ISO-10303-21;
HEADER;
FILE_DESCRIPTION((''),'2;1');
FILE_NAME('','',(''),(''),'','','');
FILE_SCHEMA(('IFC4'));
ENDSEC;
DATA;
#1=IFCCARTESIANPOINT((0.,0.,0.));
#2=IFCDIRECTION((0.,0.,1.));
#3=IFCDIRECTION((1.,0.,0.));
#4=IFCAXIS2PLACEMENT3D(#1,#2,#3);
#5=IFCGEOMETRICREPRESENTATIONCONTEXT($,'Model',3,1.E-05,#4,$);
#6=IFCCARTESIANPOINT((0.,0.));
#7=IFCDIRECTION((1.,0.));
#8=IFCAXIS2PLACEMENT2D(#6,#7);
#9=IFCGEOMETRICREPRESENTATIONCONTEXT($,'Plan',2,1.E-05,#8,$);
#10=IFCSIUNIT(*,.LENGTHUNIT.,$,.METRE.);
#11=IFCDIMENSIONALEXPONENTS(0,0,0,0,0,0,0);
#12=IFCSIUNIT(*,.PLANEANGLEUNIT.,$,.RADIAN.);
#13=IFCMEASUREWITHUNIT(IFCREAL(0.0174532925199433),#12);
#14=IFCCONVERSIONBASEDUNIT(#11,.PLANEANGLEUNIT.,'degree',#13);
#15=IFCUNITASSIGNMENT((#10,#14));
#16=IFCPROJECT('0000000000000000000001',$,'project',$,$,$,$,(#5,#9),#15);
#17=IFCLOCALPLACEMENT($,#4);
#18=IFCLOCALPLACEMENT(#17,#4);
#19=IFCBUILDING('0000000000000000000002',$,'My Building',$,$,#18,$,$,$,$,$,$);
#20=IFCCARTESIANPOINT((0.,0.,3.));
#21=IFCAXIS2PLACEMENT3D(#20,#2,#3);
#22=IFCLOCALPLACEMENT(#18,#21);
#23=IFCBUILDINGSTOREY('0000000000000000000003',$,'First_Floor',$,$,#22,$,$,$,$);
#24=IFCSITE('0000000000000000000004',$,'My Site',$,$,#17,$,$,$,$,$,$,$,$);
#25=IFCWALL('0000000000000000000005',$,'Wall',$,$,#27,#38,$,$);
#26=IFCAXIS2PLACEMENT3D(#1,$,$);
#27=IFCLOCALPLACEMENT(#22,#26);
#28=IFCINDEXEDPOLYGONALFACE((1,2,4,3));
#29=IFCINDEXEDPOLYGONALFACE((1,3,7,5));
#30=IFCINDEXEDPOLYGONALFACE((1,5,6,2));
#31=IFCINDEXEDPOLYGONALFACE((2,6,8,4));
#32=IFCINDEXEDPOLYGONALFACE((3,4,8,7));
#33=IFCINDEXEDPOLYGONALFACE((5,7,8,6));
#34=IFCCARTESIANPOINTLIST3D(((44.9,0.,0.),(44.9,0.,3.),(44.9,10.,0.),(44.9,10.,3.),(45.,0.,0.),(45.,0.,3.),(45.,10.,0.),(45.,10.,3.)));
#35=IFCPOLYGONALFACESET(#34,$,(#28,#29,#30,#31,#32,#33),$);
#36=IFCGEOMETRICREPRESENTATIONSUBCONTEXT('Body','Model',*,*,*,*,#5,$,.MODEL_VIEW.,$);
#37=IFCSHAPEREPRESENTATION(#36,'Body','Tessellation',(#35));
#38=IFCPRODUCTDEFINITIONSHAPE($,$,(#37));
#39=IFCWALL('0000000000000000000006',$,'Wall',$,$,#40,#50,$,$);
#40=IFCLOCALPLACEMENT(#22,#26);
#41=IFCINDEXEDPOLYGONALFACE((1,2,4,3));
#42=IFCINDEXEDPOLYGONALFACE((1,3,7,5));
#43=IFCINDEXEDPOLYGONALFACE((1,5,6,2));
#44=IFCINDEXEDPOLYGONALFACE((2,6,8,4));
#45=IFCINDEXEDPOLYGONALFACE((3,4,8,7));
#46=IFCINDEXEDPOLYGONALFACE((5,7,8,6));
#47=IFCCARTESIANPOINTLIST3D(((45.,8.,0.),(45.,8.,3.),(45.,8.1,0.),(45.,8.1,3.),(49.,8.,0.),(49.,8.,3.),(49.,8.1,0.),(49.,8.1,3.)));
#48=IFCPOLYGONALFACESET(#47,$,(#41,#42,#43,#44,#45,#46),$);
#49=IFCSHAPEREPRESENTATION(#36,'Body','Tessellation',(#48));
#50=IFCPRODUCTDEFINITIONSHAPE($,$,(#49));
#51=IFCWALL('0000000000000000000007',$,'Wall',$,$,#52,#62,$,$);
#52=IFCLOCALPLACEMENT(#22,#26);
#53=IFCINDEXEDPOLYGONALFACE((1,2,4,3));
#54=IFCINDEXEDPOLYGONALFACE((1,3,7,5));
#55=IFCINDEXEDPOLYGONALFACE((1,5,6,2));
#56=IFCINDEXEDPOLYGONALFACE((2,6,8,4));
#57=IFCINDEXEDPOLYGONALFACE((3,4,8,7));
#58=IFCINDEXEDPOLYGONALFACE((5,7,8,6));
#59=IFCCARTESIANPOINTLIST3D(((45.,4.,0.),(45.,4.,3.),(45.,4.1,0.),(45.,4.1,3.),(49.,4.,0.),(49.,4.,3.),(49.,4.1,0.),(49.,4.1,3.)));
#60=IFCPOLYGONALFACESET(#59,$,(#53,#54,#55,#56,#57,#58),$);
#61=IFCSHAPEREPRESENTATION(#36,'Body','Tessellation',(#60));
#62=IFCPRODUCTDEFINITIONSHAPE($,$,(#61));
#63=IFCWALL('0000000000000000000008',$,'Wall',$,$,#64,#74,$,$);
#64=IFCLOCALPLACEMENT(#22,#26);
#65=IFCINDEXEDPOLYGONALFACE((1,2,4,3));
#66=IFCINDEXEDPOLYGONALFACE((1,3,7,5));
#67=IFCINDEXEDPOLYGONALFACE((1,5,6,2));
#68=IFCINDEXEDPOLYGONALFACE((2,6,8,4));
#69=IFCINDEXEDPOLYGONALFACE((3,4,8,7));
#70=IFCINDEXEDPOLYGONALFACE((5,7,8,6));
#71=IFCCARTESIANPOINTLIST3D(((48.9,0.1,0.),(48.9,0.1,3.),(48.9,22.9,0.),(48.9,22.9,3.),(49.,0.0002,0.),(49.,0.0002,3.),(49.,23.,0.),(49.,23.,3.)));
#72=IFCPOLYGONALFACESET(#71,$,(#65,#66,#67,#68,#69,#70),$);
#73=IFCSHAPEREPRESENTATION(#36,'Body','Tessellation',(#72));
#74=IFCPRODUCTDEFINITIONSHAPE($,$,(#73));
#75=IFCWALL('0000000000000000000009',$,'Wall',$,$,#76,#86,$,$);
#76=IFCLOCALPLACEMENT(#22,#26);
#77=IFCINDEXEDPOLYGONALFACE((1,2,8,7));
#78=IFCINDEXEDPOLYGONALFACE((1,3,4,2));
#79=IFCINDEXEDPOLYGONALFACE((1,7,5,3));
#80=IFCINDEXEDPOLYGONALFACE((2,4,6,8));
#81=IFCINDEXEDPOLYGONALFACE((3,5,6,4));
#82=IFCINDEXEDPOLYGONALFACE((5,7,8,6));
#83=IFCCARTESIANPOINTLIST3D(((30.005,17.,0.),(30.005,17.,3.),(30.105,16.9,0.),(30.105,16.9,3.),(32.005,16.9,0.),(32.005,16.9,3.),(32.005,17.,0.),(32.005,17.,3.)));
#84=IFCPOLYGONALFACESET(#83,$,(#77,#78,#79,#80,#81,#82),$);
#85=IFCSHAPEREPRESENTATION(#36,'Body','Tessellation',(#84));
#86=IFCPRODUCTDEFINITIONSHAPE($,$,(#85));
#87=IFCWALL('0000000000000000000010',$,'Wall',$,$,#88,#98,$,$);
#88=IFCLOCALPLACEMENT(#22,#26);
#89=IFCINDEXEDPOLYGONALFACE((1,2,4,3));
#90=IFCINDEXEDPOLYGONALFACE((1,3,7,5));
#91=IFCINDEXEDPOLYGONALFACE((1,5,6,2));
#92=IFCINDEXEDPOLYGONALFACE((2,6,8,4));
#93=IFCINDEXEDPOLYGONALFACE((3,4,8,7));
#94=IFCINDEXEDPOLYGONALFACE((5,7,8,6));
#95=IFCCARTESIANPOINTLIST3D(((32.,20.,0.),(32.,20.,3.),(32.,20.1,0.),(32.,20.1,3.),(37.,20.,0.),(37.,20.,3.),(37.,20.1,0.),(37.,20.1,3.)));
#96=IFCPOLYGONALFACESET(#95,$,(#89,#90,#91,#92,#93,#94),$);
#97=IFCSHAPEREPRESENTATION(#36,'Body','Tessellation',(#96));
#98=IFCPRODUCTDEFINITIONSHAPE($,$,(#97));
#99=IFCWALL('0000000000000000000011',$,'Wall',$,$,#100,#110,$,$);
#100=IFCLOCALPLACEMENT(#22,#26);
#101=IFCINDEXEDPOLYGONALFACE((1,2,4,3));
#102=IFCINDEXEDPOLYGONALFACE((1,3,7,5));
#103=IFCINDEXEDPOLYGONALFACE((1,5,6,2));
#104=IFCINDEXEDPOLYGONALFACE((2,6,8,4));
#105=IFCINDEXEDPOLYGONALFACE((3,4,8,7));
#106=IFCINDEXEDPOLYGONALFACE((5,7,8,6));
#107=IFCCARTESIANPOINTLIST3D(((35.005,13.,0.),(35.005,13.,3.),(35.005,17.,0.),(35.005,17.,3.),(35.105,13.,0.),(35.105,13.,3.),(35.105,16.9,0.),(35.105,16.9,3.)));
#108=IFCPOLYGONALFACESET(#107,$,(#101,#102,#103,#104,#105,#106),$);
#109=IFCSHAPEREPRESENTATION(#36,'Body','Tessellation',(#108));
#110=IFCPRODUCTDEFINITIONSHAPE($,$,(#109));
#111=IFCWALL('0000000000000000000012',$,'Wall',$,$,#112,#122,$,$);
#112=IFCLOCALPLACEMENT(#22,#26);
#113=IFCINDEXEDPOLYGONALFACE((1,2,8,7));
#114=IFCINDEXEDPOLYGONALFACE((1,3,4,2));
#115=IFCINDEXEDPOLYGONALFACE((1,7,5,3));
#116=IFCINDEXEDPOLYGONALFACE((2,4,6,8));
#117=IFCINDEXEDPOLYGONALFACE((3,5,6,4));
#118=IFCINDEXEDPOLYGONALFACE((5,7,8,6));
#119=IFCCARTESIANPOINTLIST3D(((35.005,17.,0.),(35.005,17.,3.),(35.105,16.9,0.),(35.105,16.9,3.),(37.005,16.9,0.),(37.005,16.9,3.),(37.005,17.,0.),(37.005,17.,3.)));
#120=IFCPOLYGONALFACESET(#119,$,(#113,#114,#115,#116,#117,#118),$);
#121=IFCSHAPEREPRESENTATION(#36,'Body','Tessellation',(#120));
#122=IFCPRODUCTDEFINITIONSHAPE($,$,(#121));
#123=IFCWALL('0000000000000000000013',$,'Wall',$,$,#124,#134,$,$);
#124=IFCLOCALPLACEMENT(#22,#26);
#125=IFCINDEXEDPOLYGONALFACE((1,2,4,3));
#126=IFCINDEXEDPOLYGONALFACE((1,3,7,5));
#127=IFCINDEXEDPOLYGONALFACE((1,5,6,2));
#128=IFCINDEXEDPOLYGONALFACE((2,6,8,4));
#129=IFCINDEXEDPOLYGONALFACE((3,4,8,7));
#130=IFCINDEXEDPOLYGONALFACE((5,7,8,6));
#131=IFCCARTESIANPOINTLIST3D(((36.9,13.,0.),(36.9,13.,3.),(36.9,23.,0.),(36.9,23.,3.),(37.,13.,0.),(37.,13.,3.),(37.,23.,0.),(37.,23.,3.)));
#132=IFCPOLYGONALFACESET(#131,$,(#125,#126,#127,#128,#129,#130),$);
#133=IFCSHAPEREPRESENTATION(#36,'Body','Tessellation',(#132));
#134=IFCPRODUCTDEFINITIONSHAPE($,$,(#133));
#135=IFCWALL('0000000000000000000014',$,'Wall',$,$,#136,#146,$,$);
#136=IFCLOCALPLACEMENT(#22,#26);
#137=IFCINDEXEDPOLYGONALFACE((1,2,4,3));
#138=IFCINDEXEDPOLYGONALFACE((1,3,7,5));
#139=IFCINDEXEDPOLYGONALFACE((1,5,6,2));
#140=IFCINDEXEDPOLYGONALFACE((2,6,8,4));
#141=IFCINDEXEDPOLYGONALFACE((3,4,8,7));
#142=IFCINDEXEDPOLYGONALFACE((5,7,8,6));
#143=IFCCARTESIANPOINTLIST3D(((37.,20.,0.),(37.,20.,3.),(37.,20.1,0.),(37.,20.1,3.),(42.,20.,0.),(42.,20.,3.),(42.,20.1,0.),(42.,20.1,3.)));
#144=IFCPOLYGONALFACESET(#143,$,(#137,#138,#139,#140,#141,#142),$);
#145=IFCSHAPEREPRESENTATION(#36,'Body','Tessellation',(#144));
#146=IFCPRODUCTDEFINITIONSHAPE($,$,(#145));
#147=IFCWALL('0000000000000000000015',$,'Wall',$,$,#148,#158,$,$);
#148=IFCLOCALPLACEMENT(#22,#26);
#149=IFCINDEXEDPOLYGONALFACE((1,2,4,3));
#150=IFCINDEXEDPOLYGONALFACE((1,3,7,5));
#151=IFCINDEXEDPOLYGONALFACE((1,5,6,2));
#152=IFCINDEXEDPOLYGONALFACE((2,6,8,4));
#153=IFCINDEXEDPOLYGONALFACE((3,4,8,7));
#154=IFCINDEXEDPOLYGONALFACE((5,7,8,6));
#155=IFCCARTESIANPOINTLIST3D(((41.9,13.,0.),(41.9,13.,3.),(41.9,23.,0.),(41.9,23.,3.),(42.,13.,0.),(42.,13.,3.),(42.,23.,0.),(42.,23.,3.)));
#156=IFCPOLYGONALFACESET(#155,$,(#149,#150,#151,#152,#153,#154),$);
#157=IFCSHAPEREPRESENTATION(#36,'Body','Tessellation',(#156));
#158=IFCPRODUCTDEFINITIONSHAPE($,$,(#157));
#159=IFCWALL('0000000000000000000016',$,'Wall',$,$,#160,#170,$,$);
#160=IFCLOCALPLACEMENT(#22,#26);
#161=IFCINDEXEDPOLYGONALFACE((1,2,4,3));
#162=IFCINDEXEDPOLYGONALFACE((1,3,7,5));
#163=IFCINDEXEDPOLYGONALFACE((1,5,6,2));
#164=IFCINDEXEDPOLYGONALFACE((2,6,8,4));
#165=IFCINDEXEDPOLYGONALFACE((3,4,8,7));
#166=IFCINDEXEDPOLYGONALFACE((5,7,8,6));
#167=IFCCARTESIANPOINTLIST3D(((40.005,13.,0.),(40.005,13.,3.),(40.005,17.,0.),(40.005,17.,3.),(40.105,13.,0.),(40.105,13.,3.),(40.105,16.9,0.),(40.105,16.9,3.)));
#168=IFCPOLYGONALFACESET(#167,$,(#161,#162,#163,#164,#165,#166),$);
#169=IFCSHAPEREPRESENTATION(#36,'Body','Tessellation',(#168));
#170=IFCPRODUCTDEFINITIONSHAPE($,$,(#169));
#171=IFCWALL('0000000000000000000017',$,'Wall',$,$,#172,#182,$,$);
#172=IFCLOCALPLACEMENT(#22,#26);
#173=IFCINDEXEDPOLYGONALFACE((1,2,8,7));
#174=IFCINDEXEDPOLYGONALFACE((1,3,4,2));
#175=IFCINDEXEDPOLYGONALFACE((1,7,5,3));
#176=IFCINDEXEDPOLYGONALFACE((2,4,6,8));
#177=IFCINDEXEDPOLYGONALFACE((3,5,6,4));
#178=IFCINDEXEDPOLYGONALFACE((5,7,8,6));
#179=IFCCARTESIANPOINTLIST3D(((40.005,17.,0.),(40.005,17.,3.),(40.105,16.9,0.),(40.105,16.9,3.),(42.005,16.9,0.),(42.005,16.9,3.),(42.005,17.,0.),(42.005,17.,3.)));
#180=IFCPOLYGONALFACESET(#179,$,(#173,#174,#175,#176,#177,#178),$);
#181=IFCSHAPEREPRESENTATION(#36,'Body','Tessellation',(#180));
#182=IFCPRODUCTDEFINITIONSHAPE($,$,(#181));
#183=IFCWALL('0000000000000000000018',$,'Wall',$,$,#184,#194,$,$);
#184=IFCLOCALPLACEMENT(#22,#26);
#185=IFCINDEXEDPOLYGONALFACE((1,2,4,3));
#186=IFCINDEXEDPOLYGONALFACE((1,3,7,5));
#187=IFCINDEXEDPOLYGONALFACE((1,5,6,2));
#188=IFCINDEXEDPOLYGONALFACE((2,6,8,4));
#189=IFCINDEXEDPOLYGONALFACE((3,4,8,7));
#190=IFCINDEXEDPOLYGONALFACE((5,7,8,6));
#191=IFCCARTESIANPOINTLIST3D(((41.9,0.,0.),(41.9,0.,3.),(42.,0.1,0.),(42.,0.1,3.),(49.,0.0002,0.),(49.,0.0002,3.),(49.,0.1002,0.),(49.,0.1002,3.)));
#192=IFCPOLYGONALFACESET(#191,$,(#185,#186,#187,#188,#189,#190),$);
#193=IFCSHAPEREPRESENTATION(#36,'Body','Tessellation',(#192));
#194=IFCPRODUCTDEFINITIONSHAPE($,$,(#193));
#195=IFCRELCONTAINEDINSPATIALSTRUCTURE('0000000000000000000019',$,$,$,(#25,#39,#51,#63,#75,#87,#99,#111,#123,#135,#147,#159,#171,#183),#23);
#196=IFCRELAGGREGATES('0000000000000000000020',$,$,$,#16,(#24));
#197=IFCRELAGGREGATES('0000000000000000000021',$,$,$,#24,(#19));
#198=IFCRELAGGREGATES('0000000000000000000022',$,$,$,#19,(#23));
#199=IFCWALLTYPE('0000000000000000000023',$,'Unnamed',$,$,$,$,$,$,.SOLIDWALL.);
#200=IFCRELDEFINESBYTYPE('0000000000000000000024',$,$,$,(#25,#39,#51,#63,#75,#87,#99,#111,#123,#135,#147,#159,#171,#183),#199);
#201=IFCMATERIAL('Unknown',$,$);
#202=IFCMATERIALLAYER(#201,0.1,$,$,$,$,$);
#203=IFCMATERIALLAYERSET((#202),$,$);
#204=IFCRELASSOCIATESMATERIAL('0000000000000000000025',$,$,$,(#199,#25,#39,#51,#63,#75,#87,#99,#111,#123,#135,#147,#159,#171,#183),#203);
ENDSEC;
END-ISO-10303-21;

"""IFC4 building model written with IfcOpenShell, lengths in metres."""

from ifc_helpers import new_model, entity, si_unit, converted_unit, frame, origin_with_axes, origin_2d_with_axis, place, context, subcontext, project, spatial, line, indexed_curve, outline, extrude, material, layer, layer_set, layer_usage, type_object, element, save


model = new_model("IFC4")

# Units and contexts
model_context = context("Model", 3, precision=1e-05, world=origin_with_axes())
plan_context = context("Plan", 2, precision=1e-05, world=origin_2d_with_axis())
body_context_1 = subcontext(model_context, "Body", "Model", "MODEL_VIEW")
ifc_project = project(units=[si_unit("LENGTHUNIT", "METRE"), converted_unit("PLANEANGLEUNIT", "degree", entity("IfcReal", 0.0174532925199433), si_unit("PLANEANGLEUNIT", "RADIAN"), dimensions=[0, 0, 0, 0, 0, 0, 0])], contexts=[model_context, plan_context])

# Site, building, storey
site_placement = place(None, origin_with_axes())
site = spatial("IfcSite", under=ifc_project, at=site_placement, Name="My Site")
building_placement = place(site_placement, origin_with_axes())
building = spatial("IfcBuilding", under=site, at=building_placement, Name="My Building")
storey_placement = place(building_placement, frame((0.0, 0.0, 3.0), z_axis=(0.0, 0.0, 1.0), x_axis=(1.0, 0.0, 0.0)))
storey = spatial("IfcBuildingStorey", under=building, at=storey_placement, Name="First_Floor")

# Shared definitions
ifc_material = material(Name="Unknown")
ifc_layer = layer(ifc_material, 0.1)
ifc_layer_set = layer_set([ifc_layer])
wall_type = type_object("IfcWallType", Name="Unnamed", PredefinedType="SOLIDWALL", material=ifc_layer_set)

# Walls
ifc_layer_usage_1 = layer_usage(ifc_layer_set, "AXIS2", "POSITIVE", 0.0)
wall_1_placement = place(storey_placement, frame((44.9, 10.0, 0.0), z_axis=(0.0, 0.0, 1.0), x_axis=(0.0, -1.0, 0.0)))
element("IfcWall", 1, at=wall_1_placement, inside=storey, type_object=wall_type, material=ifc_layer_usage_1, Name="Wall", context=body_context_1, shape_type="SweptSolid", body=[
    extrude(outline(indexed_curve([(0.0, 0.0), (0.0, 0.1), (10.0, 0.1), (10.0, 0.0)], segments=[line(1, 2, 3, 4, 1)])), origin_with_axes(), (0.0, 0.0, 1.0), 3.0),
])
ifc_layer_usage_2 = layer_usage(ifc_layer_set, "AXIS2", "POSITIVE", 0.0)
wall_2_placement = place(storey_placement, frame((45.0, 8.0, 0.0), z_axis=(0.0, 0.0, 1.0), x_axis=(1.0, 0.0, 0.0)))
element("IfcWall", 2, at=wall_2_placement, inside=storey, type_object=wall_type, material=ifc_layer_usage_2, Name="Wall", context=body_context_1, shape_type="SweptSolid", body=[
    extrude(outline(indexed_curve([(0.0, 0.0), (0.0, 0.1), (4.0, 0.1), (4.0, 0.0)], segments=[line(1, 2, 3, 4, 1)])), origin_with_axes(), (0.0, 0.0, 1.0), 3.0),
])
ifc_layer_usage_3 = layer_usage(ifc_layer_set, "AXIS2", "POSITIVE", 0.0)
wall_3_placement = place(storey_placement, frame((45.0, 4.0, 0.0), z_axis=(0.0, 0.0, 1.0), x_axis=(1.0, 0.0, 0.0)))
element("IfcWall", 3, at=wall_3_placement, inside=storey, type_object=wall_type, material=ifc_layer_usage_3, Name="Wall", context=body_context_1, shape_type="SweptSolid", body=[
    extrude(outline(indexed_curve([(0.0, 0.0), (0.0, 0.1), (4.0, 0.1), (4.0, 0.0)], segments=[line(1, 2, 3, 4, 1)])), origin_with_axes(), (0.0, 0.0, 1.0), 3.0),
])
ifc_layer_usage_4 = layer_usage(ifc_layer_set, "AXIS2", "POSITIVE", 0.0)
wall_4_placement = place(storey_placement, frame((48.9, 22.9, 0.0), z_axis=(0.0, 0.0, 1.0), x_axis=(0.0, -1.0, 0.0)))
element("IfcWall", 4, at=wall_4_placement, inside=storey, type_object=wall_type, material=ifc_layer_usage_4, Name="Wall", context=body_context_1, shape_type="SweptSolid", body=[
    extrude(outline(indexed_curve([(0.0, 0.0), (-0.1, 0.1), (22.8998, 0.1), (22.8, 0.0)], segments=[line(1, 2, 3, 4, 1)])), origin_with_axes(), (0.0, 0.0, 1.0), 3.0),
])
ifc_layer_usage_5 = layer_usage(ifc_layer_set, "AXIS2", "POSITIVE", 0.0)
wall_5_placement = place(storey_placement, frame((32.005, 17.0, 0.0), z_axis=(0.0, 0.0, 1.0), x_axis=(-1.0, 0.0, 0.0)))
element("IfcWall", 5, at=wall_5_placement, inside=storey, type_object=wall_type, material=ifc_layer_usage_5, Name="Wall", context=body_context_1, shape_type="SweptSolid", body=[
    extrude(outline(indexed_curve([(0.0, 0.0), (0.0, 0.1), (1.9, 0.1), (2.0, 0.0)], segments=[line(1, 2, 3, 4, 1)])), origin_with_axes(), (0.0, 0.0, 1.0), 3.0),
])
ifc_layer_usage_6 = layer_usage(ifc_layer_set, "AXIS2", "POSITIVE", 0.0)
wall_6_placement = place(storey_placement, frame((32.0, 20.0, 0.0), z_axis=(0.0, 0.0, 1.0), x_axis=(1.0, 0.0, 0.0)))
element("IfcWall", 6, at=wall_6_placement, inside=storey, type_object=wall_type, material=ifc_layer_usage_6, Name="Wall", context=body_context_1, shape_type="SweptSolid", body=[
    extrude(outline(indexed_curve([(0.0, 0.0), (0.0, 0.1), (5.0, 0.1), (5.0, 0.0)], segments=[line(1, 2, 3, 4, 1)])), origin_with_axes(), (0.0, 0.0, 1.0), 3.0),
])
ifc_layer_usage_7 = layer_usage(ifc_layer_set, "AXIS2", "POSITIVE", 0.0)
wall_7_placement = place(storey_placement, frame((35.005, 17.0, 0.0), z_axis=(0.0, 0.0, 1.0), x_axis=(0.0, -1.0, 0.0)))
element("IfcWall", 7, at=wall_7_placement, inside=storey, type_object=wall_type, material=ifc_layer_usage_7, Name="Wall", context=body_context_1, shape_type="SweptSolid", body=[
    extrude(outline(indexed_curve([(0.0, 0.0), (0.1, 0.1), (4.0, 0.1), (4.0, 0.0)], segments=[line(1, 2, 3, 4, 1)])), origin_with_axes(), (0.0, 0.0, 1.0), 3.0),
])
ifc_layer_usage_8 = layer_usage(ifc_layer_set, "AXIS2", "POSITIVE", 0.0)
wall_8_placement = place(storey_placement, frame((37.005, 17.0, 0.0), z_axis=(0.0, 0.0, 1.0), x_axis=(-1.0, 0.0, 0.0)))
element("IfcWall", 8, at=wall_8_placement, inside=storey, type_object=wall_type, material=ifc_layer_usage_8, Name="Wall", context=body_context_1, shape_type="SweptSolid", body=[
    extrude(outline(indexed_curve([(0.0, 0.0), (0.0, 0.1), (1.9, 0.1), (2.0, 0.0)], segments=[line(1, 2, 3, 4, 1)])), origin_with_axes(), (0.0, 0.0, 1.0), 3.0),
])
ifc_layer_usage_9 = layer_usage(ifc_layer_set, "AXIS2", "POSITIVE", 0.0)
wall_9_placement = place(storey_placement, frame((36.9, 23.0, 0.0), z_axis=(0.0, 0.0, 1.0), x_axis=(0.0, -1.0, 0.0)))
element("IfcWall", 9, at=wall_9_placement, inside=storey, type_object=wall_type, material=ifc_layer_usage_9, Name="Wall", context=body_context_1, shape_type="SweptSolid", body=[
    extrude(outline(indexed_curve([(0.0, 0.0), (0.0, 0.1), (10.0, 0.1), (10.0, 0.0)], segments=[line(1, 2, 3, 4, 1)])), origin_with_axes(), (0.0, 0.0, 1.0), 3.0),
])
ifc_layer_usage_10 = layer_usage(ifc_layer_set, "AXIS2", "POSITIVE", 0.0)
wall_10_placement = place(storey_placement, frame((37.0, 20.0, 0.0), z_axis=(0.0, 0.0, 1.0), x_axis=(1.0, 0.0, 0.0)))
element("IfcWall", 10, at=wall_10_placement, inside=storey, type_object=wall_type, material=ifc_layer_usage_10, Name="Wall", context=body_context_1, shape_type="SweptSolid", body=[
    extrude(outline(indexed_curve([(0.0, 0.0), (0.0, 0.1), (5.0, 0.1), (5.0, 0.0)], segments=[line(1, 2, 3, 4, 1)])), origin_with_axes(), (0.0, 0.0, 1.0), 3.0),
])
ifc_layer_usage_11 = layer_usage(ifc_layer_set, "AXIS2", "POSITIVE", 0.0)
wall_11_placement = place(storey_placement, frame((41.9, 23.0, 0.0), z_axis=(0.0, 0.0, 1.0), x_axis=(0.0, -1.0, 0.0)))
element("IfcWall", 11, at=wall_11_placement, inside=storey, type_object=wall_type, material=ifc_layer_usage_11, Name="Wall", context=body_context_1, shape_type="SweptSolid", body=[
    extrude(outline(indexed_curve([(0.0, 0.0), (0.0, 0.1), (10.0, 0.1), (10.0, 0.0)], segments=[line(1, 2, 3, 4, 1)])), origin_with_axes(), (0.0, 0.0, 1.0), 3.0),
])
ifc_layer_usage_12 = layer_usage(ifc_layer_set, "AXIS2", "POSITIVE", 0.0)
wall_12_placement = place(storey_placement, frame((40.005, 17.0, 0.0), z_axis=(0.0, 0.0, 1.0), x_axis=(0.0, -1.0, 0.0)))
element("IfcWall", 12, at=wall_12_placement, inside=storey, type_object=wall_type, material=ifc_layer_usage_12, Name="Wall", context=body_context_1, shape_type="SweptSolid", body=[
    extrude(outline(indexed_curve([(0.0, 0.0), (0.1, 0.1), (4.0, 0.1), (4.0, 0.0)], segments=[line(1, 2, 3, 4, 1)])), origin_with_axes(), (0.0, 0.0, 1.0), 3.0),
])
ifc_layer_usage_13 = layer_usage(ifc_layer_set, "AXIS2", "POSITIVE", 0.0)
wall_13_placement = place(storey_placement, frame((42.005, 17.0, 0.0), z_axis=(0.0, 0.0, 1.0), x_axis=(-1.0, 0.0, 0.0)))
element("IfcWall", 13, at=wall_13_placement, inside=storey, type_object=wall_type, material=ifc_layer_usage_13, Name="Wall", context=body_context_1, shape_type="SweptSolid", body=[
    extrude(outline(indexed_curve([(0.0, 0.0), (0.0, 0.1), (1.9, 0.1), (2.0, 0.0)], segments=[line(1, 2, 3, 4, 1)])), origin_with_axes(), (0.0, 0.0, 1.0), 3.0),
])
ifc_layer_usage_14 = layer_usage(ifc_layer_set, "AXIS2", "POSITIVE", 0.0)
wall_14_placement = place(storey_placement, frame((41.9, 0.0, 0.0), z_axis=(0.0, 0.0, 1.0), x_axis=(1.0, 0.000029, 0.0)))
element("IfcWall", 14, at=wall_14_placement, inside=storey, type_object=wall_type, material=ifc_layer_usage_14, Name="Wall", context=body_context_1, shape_type="SweptSolid", body=[
    extrude(outline(indexed_curve([(0.0, 0.0), (0.1, 0.1), (7.1, 0.1), (7.1, 0.0)], segments=[line(1, 2, 3, 4, 1)])), origin_with_axes(), (0.0, 0.0, 1.0), 3.0),
])

save(model, "model.ifc")
